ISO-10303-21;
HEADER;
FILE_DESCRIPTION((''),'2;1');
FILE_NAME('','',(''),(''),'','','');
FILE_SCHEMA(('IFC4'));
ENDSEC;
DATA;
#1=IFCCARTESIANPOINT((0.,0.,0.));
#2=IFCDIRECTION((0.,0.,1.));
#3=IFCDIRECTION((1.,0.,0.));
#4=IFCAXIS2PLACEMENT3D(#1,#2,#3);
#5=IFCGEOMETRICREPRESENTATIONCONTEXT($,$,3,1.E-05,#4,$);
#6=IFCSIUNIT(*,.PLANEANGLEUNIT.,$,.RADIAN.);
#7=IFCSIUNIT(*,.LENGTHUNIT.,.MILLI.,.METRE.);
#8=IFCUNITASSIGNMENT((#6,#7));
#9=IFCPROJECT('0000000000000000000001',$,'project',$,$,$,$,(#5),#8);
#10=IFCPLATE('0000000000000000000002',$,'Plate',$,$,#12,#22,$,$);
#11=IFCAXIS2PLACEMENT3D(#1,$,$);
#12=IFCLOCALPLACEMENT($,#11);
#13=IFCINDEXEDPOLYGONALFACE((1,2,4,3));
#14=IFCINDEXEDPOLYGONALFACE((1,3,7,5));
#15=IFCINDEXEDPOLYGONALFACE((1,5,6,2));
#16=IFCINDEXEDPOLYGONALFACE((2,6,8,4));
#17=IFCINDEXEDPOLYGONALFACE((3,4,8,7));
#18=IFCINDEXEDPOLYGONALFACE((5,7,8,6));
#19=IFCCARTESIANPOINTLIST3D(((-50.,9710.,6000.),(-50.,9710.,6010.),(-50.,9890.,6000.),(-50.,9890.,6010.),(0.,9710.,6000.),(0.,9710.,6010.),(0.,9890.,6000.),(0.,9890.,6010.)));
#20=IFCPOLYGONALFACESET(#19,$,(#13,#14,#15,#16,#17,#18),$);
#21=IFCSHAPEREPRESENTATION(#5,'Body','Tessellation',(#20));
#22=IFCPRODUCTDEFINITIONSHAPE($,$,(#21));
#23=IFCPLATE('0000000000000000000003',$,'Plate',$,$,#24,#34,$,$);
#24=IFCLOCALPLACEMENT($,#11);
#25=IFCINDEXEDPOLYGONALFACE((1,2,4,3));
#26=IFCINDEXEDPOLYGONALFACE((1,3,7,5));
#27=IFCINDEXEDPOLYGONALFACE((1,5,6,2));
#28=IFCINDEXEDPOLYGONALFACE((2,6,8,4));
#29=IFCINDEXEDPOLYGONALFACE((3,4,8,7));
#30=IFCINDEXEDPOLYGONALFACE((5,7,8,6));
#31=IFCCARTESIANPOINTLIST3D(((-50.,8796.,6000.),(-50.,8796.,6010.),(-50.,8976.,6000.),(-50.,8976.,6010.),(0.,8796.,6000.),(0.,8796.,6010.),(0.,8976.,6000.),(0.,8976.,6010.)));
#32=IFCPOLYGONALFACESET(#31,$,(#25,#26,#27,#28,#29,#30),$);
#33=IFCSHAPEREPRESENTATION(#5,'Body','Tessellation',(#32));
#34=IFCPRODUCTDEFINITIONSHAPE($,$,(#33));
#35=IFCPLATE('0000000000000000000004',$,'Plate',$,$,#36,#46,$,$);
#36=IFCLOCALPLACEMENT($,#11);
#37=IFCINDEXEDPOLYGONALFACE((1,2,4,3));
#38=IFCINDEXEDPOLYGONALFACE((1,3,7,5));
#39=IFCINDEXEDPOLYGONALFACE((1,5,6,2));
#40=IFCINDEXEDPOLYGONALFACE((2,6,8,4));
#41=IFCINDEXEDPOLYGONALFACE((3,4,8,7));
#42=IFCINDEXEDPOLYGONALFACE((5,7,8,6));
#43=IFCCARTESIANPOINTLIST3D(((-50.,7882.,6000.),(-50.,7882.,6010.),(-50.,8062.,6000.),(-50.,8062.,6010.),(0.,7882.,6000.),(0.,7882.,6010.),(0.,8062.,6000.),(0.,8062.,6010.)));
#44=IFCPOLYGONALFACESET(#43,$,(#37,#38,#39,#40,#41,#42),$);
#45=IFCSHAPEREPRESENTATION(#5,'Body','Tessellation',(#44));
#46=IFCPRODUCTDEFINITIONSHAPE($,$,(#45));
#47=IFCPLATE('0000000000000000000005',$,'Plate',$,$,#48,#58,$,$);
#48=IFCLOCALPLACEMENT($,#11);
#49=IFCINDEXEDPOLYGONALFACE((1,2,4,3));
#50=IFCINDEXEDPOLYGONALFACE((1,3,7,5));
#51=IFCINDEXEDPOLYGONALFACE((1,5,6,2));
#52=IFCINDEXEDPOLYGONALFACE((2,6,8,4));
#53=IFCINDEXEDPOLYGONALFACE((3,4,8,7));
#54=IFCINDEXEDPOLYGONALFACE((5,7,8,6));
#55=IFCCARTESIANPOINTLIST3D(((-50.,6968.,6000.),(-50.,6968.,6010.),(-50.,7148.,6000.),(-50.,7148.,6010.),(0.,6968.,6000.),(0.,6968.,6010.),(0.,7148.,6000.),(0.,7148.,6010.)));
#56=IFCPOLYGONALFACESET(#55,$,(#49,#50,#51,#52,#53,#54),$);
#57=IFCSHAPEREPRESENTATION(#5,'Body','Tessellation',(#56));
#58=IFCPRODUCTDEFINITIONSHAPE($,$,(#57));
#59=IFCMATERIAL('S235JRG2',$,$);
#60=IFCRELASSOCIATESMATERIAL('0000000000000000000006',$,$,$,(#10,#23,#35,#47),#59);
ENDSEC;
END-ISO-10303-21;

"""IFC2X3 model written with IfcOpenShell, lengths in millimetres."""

from ifc_helpers import new_model, si_unit, frame, origin_with_axes, place, context, project, polyline, outline, extrude, material, element, save


model = new_model("IFC2X3")

# Units and contexts
context_of_model = context(None, 3, precision=1e-05, world=origin_with_axes())
ifc_project = project(units=[si_unit("PLANEANGLEUNIT", "RADIAN"), si_unit("LENGTHUNIT", "METRE", prefix="MILLI")], contexts=[context_of_model])

# Shared definitions
ifc_material = material(Name="S235JRG2")

# Plates
placement_1 = place(None, origin_with_axes())
plate_1_placement = place(placement_1, frame((0.0, 9890.0, 6010.0), z_axis=(-1.0, 0.0, 0.0), x_axis=(0.0, 0.0, -1.0)))
element("IfcPlate", 1, at=plate_1_placement, material=ifc_material, Name="Plate", context=context_of_model, shape_type="SweptSolid", body=[
    extrude(outline(polyline([(0.0, 0.0), (180.0, 0.0), (180.0, 50.0), (0.0, 50.0), (0.0, 0.0)])), frame((0.0, 0.0, 0.0), z_axis=(1.0, 0.0, 0.0), x_axis=(0.0, 1.0, 0.0)), (0.0, 0.0, 1.0), 10.0),
])
placement_2 = place(None, origin_with_axes())
plate_2_placement = place(placement_2, frame((0.0, 8976.0, 6010.0), z_axis=(-1.0, 0.0, 0.0), x_axis=(0.0, 0.0, -1.0)))
element("IfcPlate", 2, at=plate_2_placement, material=ifc_material, Name="Plate", context=context_of_model, shape_type="SweptSolid", body=[
    extrude(outline(polyline([(0.0, 0.0), (180.0, 0.0), (180.0, 50.0), (0.0, 50.0), (0.0, 0.0)])), frame((0.0, 0.0, 0.0), z_axis=(1.0, 0.0, 0.0), x_axis=(0.0, 1.0, 0.0)), (0.0, 0.0, 1.0), 10.0),
])
placement_3 = place(None, origin_with_axes())
plate_3_placement = place(placement_3, frame((0.0, 8062.0, 6010.0), z_axis=(-1.0, 0.0, 0.0), x_axis=(0.0, 0.0, -1.0)))
element("IfcPlate", 3, at=plate_3_placement, material=ifc_material, Name="Plate", context=context_of_model, shape_type="SweptSolid", body=[
    extrude(outline(polyline([(0.0, 0.0), (180.0, 0.0), (180.0, 50.0), (0.0, 50.0), (0.0, 0.0)])), frame((0.0, 0.0, 0.0), z_axis=(1.0, 0.0, 0.0), x_axis=(0.0, 1.0, 0.0)), (0.0, 0.0, 1.0), 10.0),
])
placement_4 = place(None, origin_with_axes())
plate_4_placement = place(placement_4, frame((0.0, 7148.0, 6010.0), z_axis=(-1.0, 0.0, 0.0), x_axis=(0.0, 0.0, -1.0)))
element("IfcPlate", 4, at=plate_4_placement, material=ifc_material, Name="Plate", context=context_of_model, shape_type="SweptSolid", body=[
    extrude(outline(polyline([(0.0, 0.0), (180.0, 0.0), (180.0, 50.0), (0.0, 50.0), (0.0, 0.0)])), frame((0.0, 0.0, 0.0), z_axis=(1.0, 0.0, 0.0), x_axis=(0.0, 1.0, 0.0)), (0.0, 0.0, 1.0), 10.0),
])

save(model, "model.ifc")
